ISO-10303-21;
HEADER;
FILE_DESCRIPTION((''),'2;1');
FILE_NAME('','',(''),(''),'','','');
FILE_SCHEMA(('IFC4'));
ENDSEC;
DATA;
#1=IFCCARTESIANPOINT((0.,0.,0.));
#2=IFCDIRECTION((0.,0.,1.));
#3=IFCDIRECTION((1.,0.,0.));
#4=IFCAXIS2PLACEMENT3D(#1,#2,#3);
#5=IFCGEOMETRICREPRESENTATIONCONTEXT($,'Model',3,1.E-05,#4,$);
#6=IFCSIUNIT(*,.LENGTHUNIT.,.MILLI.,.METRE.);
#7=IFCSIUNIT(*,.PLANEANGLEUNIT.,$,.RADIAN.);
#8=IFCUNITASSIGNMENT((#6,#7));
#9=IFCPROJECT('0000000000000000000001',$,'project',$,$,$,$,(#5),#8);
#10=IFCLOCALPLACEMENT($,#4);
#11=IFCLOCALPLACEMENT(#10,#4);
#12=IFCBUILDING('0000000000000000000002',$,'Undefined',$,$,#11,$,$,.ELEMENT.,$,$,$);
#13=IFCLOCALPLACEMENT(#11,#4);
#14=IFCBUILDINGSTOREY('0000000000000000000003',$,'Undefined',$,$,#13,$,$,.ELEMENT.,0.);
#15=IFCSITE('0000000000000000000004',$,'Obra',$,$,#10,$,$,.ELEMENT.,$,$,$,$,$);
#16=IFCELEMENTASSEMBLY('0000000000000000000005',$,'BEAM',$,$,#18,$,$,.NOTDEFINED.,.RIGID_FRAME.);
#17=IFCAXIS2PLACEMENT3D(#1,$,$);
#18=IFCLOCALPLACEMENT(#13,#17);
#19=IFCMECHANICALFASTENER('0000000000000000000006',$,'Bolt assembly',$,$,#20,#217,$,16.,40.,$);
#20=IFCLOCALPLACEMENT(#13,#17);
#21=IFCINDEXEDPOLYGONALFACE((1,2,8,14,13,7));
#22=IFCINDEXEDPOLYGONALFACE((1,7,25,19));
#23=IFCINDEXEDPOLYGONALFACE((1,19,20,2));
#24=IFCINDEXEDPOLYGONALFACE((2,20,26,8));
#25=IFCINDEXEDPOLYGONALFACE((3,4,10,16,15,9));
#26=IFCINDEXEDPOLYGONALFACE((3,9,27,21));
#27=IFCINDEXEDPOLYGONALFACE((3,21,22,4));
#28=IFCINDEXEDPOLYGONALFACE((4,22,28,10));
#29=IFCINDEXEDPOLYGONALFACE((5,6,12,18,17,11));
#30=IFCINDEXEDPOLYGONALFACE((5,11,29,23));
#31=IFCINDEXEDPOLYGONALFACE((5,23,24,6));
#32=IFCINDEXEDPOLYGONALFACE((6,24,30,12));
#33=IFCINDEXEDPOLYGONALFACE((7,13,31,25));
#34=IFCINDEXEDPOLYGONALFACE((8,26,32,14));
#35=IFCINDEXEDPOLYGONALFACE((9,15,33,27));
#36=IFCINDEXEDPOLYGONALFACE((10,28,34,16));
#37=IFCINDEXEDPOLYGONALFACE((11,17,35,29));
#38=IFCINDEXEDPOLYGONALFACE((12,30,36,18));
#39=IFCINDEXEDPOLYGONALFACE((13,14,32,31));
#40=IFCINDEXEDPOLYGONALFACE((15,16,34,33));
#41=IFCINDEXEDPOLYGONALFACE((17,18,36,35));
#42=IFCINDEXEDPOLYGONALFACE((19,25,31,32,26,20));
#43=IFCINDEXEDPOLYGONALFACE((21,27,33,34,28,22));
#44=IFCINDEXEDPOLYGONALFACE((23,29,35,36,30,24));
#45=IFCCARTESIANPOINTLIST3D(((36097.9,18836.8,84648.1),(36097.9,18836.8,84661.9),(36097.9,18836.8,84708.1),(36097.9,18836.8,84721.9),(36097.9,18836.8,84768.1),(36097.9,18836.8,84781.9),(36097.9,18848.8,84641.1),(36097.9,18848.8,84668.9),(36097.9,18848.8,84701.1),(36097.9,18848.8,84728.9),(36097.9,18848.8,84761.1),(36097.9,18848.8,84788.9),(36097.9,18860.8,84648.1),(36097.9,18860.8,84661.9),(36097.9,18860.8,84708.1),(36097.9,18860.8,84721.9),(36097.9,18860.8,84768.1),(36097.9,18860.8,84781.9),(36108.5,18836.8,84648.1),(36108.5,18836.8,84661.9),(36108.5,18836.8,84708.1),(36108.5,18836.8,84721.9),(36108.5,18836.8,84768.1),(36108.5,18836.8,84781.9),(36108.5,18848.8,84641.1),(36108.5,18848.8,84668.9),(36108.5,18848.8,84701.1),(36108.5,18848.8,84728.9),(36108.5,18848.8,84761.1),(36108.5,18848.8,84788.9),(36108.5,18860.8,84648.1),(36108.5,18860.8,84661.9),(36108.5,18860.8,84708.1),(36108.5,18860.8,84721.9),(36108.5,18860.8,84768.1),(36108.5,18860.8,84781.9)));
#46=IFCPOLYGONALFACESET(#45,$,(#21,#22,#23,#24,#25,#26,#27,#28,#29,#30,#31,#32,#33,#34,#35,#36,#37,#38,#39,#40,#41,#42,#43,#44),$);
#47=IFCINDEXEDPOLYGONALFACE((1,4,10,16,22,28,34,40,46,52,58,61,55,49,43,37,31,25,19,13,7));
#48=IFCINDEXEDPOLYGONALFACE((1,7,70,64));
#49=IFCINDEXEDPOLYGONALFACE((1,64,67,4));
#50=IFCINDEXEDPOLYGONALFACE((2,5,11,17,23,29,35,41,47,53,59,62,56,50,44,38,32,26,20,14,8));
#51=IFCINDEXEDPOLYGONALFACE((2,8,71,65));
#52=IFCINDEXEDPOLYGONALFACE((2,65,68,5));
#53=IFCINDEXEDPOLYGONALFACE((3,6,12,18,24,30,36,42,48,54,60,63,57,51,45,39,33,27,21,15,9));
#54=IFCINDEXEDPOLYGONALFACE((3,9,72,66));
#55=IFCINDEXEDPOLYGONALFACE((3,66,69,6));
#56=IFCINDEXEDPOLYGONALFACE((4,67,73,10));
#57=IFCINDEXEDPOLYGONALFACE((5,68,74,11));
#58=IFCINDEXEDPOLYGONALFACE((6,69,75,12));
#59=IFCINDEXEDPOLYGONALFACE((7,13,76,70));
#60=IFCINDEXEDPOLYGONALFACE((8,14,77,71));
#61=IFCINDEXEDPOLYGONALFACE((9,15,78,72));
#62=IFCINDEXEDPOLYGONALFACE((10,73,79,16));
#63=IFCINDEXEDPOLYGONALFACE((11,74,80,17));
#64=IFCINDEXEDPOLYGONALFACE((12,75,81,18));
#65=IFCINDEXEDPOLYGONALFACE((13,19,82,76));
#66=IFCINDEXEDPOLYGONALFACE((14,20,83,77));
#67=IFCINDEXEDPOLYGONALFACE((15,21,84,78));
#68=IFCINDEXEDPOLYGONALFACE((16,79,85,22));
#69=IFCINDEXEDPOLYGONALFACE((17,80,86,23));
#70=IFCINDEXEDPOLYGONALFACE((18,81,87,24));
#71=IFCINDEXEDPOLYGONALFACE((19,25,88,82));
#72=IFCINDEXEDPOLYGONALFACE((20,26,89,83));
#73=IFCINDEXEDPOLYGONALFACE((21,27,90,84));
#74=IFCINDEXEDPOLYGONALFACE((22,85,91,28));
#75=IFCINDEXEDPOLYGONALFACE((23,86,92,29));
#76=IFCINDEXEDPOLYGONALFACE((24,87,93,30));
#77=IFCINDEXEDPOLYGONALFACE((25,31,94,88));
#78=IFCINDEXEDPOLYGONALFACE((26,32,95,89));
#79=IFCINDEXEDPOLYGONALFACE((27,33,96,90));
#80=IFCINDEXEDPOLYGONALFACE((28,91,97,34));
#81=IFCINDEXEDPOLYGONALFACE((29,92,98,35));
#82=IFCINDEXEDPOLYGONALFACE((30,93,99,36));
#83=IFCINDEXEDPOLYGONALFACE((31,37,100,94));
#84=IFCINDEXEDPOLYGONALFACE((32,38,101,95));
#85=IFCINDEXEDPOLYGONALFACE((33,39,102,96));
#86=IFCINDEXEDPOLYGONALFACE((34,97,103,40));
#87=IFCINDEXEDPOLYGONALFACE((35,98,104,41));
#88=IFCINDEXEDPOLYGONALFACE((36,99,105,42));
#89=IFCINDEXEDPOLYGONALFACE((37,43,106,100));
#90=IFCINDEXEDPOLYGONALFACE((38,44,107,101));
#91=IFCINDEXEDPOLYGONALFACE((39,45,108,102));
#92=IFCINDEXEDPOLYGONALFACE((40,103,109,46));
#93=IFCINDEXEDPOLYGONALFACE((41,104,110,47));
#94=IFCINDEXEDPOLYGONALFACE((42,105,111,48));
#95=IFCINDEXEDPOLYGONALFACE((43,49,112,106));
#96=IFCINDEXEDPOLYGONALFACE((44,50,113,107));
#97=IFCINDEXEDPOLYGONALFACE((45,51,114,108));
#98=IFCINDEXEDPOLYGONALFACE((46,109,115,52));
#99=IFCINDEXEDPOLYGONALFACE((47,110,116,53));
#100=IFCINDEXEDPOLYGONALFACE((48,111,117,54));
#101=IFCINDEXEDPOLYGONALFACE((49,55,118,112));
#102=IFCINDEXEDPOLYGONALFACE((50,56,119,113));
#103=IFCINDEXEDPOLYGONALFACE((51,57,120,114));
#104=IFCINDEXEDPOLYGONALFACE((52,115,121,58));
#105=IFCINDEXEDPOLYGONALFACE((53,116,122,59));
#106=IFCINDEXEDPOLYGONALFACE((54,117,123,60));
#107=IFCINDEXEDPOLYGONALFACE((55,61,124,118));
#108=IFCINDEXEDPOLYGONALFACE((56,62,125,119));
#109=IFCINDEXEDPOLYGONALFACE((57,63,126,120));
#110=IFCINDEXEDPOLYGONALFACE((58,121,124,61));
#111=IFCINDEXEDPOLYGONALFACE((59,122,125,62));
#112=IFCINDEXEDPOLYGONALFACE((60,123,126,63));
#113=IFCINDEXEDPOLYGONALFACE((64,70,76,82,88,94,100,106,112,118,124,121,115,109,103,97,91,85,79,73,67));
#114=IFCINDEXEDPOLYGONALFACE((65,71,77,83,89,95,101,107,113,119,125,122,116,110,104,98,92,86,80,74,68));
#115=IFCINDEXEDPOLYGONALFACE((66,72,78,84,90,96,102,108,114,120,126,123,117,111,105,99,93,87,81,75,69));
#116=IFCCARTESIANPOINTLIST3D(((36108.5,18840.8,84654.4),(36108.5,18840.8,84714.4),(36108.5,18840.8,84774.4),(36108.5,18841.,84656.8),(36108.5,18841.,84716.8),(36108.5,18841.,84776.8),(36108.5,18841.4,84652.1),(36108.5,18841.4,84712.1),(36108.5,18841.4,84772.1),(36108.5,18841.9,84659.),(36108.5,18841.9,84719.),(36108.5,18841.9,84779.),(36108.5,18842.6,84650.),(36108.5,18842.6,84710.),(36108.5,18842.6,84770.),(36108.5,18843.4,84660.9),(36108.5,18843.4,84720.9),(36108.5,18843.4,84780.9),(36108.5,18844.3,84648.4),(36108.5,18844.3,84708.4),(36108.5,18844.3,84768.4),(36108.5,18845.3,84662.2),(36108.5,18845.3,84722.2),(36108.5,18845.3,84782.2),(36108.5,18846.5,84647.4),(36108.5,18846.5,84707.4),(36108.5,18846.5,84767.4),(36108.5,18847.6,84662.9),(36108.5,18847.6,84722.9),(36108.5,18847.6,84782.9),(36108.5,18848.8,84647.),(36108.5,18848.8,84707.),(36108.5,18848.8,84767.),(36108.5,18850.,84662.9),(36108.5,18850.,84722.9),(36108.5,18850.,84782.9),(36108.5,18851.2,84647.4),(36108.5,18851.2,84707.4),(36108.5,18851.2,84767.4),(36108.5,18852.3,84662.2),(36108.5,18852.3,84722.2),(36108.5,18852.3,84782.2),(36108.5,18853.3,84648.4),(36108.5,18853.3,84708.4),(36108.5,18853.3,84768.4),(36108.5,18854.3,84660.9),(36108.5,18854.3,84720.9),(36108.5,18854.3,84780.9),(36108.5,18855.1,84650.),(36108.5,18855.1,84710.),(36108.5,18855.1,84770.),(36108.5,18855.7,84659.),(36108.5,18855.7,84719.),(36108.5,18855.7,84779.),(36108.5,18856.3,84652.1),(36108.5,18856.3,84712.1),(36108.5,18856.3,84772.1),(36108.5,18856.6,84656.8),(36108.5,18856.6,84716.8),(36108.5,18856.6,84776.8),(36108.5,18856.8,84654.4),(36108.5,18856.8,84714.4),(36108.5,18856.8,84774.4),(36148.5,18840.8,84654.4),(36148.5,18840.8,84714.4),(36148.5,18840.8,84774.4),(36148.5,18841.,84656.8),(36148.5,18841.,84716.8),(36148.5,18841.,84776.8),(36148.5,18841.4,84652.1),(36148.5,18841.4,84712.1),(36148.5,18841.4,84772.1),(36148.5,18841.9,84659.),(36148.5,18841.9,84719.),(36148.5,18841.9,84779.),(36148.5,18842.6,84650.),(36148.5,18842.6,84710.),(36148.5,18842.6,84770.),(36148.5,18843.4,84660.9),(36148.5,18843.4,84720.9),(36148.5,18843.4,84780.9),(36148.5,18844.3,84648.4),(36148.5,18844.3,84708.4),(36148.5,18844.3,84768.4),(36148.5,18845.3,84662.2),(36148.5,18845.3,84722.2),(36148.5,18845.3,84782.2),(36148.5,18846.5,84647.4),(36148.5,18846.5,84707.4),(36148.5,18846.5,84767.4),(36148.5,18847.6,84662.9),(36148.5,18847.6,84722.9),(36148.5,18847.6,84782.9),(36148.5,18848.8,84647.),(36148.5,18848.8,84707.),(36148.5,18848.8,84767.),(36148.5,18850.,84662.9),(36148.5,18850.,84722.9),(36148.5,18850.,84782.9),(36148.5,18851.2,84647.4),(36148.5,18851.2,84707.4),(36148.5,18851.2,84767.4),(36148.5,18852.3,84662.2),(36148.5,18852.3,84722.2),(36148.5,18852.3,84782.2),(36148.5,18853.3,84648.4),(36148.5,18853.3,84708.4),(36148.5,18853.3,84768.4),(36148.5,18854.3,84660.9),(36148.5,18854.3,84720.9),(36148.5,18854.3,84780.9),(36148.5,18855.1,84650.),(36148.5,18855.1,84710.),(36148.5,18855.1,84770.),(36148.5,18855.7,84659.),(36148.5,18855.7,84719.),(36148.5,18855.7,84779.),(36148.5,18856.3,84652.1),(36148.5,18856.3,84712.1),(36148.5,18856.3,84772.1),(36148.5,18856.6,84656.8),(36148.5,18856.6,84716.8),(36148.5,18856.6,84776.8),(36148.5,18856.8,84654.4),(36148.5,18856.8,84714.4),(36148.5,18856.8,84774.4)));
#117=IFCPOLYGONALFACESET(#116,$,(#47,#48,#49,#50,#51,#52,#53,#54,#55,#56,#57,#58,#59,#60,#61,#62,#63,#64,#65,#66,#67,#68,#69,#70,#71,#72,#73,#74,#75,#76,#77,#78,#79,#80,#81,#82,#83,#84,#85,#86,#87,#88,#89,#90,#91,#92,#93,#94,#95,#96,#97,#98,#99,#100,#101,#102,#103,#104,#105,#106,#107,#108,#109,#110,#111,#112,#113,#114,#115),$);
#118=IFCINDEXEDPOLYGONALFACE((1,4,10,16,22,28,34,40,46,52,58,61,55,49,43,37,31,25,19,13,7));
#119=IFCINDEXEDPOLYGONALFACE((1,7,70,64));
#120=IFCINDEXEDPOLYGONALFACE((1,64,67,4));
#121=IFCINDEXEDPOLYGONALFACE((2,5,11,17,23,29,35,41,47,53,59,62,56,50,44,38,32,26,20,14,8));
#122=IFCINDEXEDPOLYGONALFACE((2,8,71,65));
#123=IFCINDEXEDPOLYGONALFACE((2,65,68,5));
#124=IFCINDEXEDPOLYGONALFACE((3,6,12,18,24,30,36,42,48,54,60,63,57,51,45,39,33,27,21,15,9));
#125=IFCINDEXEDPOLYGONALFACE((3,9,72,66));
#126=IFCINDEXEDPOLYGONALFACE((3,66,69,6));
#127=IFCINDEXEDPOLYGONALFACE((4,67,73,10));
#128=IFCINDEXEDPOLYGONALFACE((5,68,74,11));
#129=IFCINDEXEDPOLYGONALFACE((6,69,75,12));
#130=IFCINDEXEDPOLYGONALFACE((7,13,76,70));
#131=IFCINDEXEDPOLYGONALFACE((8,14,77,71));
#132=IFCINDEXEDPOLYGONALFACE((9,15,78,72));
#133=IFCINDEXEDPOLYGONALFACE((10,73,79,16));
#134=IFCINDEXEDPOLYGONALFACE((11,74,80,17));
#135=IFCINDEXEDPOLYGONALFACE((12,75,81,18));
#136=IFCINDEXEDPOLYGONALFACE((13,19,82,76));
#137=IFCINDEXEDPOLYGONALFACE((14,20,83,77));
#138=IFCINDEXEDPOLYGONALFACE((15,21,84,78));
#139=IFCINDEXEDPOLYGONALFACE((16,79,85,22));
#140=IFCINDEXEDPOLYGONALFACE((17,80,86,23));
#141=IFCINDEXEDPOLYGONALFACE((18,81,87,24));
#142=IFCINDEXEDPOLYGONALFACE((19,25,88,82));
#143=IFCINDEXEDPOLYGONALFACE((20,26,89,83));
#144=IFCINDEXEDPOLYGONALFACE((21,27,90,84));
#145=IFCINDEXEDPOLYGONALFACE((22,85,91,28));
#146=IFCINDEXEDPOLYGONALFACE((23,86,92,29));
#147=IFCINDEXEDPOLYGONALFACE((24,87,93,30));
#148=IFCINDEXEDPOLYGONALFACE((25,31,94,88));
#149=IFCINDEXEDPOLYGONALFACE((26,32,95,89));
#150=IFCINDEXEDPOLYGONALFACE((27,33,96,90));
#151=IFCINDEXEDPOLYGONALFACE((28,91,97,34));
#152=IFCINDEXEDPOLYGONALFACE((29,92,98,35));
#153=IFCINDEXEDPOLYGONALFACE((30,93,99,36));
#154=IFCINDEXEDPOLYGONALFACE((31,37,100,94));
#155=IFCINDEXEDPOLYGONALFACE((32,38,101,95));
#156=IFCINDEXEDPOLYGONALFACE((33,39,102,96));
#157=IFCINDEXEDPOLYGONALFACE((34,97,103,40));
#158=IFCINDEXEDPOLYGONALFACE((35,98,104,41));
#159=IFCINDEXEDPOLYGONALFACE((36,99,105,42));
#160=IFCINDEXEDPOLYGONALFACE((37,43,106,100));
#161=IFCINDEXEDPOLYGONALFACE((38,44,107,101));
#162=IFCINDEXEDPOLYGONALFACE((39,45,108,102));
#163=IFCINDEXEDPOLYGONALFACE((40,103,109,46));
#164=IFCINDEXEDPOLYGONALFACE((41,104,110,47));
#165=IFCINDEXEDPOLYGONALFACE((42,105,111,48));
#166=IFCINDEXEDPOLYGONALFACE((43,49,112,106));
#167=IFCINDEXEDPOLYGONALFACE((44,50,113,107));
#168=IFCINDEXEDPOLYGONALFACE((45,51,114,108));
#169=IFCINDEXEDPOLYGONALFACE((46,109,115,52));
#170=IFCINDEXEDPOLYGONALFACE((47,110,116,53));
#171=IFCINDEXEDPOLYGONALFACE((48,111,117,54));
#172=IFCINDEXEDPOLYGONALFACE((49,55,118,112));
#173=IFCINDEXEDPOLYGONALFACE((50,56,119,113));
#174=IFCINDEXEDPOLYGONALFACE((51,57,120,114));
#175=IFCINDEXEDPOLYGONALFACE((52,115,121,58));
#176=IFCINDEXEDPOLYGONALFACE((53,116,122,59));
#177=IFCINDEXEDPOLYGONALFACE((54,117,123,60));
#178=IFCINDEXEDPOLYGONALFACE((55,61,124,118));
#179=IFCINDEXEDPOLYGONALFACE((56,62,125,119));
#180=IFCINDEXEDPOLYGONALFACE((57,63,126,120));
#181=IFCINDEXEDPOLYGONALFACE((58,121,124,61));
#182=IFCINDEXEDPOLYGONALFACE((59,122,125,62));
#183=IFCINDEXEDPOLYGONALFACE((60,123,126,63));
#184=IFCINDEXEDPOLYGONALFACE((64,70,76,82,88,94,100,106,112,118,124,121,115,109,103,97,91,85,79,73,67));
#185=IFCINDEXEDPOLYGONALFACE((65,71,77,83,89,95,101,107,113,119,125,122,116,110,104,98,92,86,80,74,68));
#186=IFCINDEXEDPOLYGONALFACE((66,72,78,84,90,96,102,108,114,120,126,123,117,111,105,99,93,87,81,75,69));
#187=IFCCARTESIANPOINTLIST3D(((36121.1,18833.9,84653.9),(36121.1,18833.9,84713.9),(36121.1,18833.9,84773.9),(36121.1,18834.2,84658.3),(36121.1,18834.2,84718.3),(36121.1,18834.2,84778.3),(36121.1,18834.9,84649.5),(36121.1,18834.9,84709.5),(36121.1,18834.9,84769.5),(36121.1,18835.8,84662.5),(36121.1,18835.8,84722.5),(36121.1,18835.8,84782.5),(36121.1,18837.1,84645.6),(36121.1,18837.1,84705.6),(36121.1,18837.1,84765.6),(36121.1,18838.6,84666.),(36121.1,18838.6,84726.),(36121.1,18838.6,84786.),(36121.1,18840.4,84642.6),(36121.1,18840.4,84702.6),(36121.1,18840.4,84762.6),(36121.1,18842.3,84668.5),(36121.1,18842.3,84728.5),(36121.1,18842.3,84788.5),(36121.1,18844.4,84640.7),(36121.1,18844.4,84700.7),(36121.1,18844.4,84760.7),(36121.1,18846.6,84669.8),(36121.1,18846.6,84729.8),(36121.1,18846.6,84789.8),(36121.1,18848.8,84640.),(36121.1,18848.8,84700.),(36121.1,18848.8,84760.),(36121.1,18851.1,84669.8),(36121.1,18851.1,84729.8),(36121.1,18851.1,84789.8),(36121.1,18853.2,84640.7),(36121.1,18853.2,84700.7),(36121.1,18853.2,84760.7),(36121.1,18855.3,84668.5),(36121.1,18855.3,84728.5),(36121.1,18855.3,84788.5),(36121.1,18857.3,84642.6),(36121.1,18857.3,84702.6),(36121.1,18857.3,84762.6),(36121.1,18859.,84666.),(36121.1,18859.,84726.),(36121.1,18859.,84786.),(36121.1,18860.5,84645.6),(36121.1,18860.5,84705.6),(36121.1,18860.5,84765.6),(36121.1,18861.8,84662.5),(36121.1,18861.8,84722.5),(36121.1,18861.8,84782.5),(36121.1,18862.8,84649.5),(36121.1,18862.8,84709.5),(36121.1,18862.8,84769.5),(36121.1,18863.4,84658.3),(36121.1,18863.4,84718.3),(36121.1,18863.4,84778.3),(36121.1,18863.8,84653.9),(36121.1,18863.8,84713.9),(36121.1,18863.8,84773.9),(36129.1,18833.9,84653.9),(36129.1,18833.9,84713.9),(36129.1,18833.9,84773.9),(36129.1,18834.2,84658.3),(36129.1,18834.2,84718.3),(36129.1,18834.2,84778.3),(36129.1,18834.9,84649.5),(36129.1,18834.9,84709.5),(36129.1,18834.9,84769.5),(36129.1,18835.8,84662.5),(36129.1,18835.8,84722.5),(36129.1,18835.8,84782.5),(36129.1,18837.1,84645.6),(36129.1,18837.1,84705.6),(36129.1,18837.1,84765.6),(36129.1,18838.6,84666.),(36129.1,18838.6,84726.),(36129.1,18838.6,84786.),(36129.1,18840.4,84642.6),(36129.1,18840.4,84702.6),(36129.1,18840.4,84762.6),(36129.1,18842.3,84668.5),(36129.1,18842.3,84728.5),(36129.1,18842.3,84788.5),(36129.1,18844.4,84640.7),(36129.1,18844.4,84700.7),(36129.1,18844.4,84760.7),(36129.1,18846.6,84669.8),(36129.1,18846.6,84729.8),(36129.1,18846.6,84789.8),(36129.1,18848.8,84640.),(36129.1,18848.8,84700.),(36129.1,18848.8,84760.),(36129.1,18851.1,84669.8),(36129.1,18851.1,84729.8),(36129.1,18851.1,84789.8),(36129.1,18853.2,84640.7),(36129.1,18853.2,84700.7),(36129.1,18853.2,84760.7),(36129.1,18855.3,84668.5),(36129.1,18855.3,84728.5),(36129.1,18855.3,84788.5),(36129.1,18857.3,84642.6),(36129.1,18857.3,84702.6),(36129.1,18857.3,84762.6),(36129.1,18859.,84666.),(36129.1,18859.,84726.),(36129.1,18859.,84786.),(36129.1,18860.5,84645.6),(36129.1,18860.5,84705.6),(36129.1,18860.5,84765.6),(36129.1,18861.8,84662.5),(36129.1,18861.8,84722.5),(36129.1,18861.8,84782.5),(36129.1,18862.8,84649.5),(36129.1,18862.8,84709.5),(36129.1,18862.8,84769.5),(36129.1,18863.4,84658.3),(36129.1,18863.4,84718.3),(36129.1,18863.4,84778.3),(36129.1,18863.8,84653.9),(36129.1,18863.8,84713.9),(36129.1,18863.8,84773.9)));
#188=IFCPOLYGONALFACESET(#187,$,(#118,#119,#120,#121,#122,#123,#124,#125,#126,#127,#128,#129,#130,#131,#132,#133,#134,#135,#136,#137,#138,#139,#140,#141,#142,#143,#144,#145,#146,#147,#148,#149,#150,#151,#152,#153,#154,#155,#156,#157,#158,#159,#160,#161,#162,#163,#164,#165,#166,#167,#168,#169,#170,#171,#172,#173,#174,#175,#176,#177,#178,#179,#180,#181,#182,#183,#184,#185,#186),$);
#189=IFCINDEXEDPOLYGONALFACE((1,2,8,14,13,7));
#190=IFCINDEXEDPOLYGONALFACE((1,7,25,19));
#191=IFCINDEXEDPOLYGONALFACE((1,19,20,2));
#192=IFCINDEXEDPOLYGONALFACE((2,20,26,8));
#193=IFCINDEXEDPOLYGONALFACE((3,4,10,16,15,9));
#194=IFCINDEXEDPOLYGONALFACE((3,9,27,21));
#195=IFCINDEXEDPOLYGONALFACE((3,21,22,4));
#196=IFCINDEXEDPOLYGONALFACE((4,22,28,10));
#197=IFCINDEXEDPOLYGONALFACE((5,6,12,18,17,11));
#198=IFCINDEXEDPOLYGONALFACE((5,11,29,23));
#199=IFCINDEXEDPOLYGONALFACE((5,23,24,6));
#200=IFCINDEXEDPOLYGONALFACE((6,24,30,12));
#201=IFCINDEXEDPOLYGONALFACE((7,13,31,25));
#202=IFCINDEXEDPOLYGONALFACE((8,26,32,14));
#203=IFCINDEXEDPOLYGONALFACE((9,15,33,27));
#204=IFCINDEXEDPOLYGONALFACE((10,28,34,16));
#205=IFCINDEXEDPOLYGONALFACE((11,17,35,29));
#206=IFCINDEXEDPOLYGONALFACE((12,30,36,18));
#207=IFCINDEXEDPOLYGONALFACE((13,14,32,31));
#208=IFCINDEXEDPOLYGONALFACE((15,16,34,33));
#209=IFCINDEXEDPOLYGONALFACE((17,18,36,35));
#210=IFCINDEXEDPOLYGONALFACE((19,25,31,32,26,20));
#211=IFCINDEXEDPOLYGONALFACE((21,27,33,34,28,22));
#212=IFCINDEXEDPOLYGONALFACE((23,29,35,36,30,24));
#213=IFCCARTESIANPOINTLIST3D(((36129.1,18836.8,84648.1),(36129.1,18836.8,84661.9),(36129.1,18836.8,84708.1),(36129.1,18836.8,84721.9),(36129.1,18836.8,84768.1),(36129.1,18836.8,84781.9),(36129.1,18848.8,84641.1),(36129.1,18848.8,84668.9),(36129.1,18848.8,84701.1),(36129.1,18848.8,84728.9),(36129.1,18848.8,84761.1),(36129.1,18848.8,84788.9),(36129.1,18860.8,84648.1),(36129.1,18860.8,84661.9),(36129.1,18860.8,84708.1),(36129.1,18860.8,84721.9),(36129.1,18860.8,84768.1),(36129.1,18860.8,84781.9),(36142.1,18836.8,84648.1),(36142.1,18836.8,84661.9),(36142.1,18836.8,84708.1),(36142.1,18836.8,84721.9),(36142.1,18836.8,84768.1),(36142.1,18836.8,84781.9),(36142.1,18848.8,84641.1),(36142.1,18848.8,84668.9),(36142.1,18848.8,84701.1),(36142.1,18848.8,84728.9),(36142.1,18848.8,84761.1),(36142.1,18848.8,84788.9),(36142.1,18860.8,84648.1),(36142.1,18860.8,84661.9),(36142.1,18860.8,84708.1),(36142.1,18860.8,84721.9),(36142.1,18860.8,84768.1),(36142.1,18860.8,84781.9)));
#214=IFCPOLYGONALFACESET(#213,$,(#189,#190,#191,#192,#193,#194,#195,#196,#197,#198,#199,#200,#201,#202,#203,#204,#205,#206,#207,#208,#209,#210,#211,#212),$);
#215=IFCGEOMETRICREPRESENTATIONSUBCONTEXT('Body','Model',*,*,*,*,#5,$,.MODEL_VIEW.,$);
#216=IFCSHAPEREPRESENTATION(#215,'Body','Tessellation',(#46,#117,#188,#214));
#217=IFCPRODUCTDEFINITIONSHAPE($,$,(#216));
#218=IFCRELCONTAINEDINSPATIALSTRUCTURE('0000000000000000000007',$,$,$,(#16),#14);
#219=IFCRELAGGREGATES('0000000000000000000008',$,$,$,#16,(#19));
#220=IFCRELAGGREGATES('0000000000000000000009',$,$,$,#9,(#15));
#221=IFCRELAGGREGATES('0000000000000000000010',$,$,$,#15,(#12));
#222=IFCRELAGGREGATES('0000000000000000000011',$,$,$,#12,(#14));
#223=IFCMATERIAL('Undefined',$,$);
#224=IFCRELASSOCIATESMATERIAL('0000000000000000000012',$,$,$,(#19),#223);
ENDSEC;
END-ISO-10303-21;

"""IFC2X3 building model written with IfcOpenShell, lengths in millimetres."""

from ifc_helpers import new_model, si_unit, frame, origin_with_axes, origin_2d_with_axis, place, context, subcontext, project, spatial, polyline, circle, outline, extrude, source, transform, mapped, material, element, aggregate, save


model = new_model("IFC2X3")

# Units and contexts
model_context = context("Model", 3, precision=1e-05, world=origin_with_axes())
body_context = subcontext(model_context, "Body", "Model", "MODEL_VIEW")
ifc_project = project(units=[si_unit("LENGTHUNIT", "METRE", prefix="MILLI"), si_unit("PLANEANGLEUNIT", "RADIAN")], contexts=[model_context])

# Site, building, storey
site_placement = place(None, origin_with_axes())
site = spatial("IfcSite", under=ifc_project, at=site_placement, Name="Obra", CompositionType="ELEMENT")
building_placement = place(site_placement, origin_with_axes())
building = spatial("IfcBuilding", under=site, at=building_placement, Name="Undefined", CompositionType="ELEMENT")
storey_placement = place(building_placement, origin_with_axes())
storey = spatial("IfcBuildingStorey", under=building, at=storey_placement, Name="Undefined", CompositionType="ELEMENT", Elevation=0.0)

# Element assembly
assembly_1_placement = place(storey_placement, origin_with_axes())
assembly_1 = element("IfcElementAssembly", 1, at=assembly_1_placement, inside=storey, Name="BEAM", AssemblyPlace="NOTDEFINED", PredefinedType="RIGID_FRAME")
ifc_material_1 = material(Name="Undefined")
shared_shape_1 = source(origin_with_axes(), body_context, "Body", "SweptSolid", [
    extrude(outline(polyline([(13.9, 0.0), (6.9, 12.0), (-6.9, 12.0), (-13.9, 0.0), (-6.9, -12.0), (6.9, -12.0), (13.9, 0.0)])), frame((0.0, -19.9, 0.0), z_axis=(0.0, 1.0, 0.0), x_axis=(1.0, 0.0, 0.0)), (0.0, 0.0, 1.0), 10.6),
    extrude(circle(Radius=8.0, at=origin_2d_with_axis()), frame((0.0, -9.3, 0.0), z_axis=(0.0, 1.0, 0.0), x_axis=(1.0, 0.0, 0.0)), (0.0, 0.0, 1.0), 40.0),
    extrude(circle(Radius=15.0, at=origin_2d_with_axis()), frame((0.0, 3.3, 0.0), z_axis=(0.0, 1.0, 0.0), x_axis=(1.0, 0.0, 0.0)), (0.0, 0.0, 1.0), 8.0),
    extrude(outline(polyline([(13.9, 0.0), (6.9, 12.0), (-6.9, 12.0), (-13.9, 0.0), (-6.9, -12.0), (6.9, -12.0), (13.9, 0.0)])), frame((0.0, 11.3, 0.0), z_axis=(0.0, 1.0, 0.0), x_axis=(1.0, 0.0, 0.0)), (0.0, 0.0, 1.0), 13.0),
])

# Mechanical fastener
mechanical_fastener_1_placement = place(assembly_1_placement, frame((36117.8, 18898.8, 84850.0), z_axis=(0.0, -1.0, 0.0), x_axis=(0.0, 0.0, -1.0)))
mechanical_fastener_1 = element("IfcMechanicalFastener", 2, at=mechanical_fastener_1_placement, material=ifc_material_1, Name="Bolt assembly", NominalDiameter=16.0, NominalLength=40.0, context=body_context, shape_type="MappedRepresentation", body=[
    mapped(shared_shape_1, transform((75.0, 0.0, 50.0))),
    mapped(shared_shape_1, transform((135.0, 0.0, 50.0))),
    mapped(shared_shape_1, transform((195.0, 0.0, 50.0))),
])
aggregate(assembly_1, [mechanical_fastener_1])

save(model, "model.ifc")
